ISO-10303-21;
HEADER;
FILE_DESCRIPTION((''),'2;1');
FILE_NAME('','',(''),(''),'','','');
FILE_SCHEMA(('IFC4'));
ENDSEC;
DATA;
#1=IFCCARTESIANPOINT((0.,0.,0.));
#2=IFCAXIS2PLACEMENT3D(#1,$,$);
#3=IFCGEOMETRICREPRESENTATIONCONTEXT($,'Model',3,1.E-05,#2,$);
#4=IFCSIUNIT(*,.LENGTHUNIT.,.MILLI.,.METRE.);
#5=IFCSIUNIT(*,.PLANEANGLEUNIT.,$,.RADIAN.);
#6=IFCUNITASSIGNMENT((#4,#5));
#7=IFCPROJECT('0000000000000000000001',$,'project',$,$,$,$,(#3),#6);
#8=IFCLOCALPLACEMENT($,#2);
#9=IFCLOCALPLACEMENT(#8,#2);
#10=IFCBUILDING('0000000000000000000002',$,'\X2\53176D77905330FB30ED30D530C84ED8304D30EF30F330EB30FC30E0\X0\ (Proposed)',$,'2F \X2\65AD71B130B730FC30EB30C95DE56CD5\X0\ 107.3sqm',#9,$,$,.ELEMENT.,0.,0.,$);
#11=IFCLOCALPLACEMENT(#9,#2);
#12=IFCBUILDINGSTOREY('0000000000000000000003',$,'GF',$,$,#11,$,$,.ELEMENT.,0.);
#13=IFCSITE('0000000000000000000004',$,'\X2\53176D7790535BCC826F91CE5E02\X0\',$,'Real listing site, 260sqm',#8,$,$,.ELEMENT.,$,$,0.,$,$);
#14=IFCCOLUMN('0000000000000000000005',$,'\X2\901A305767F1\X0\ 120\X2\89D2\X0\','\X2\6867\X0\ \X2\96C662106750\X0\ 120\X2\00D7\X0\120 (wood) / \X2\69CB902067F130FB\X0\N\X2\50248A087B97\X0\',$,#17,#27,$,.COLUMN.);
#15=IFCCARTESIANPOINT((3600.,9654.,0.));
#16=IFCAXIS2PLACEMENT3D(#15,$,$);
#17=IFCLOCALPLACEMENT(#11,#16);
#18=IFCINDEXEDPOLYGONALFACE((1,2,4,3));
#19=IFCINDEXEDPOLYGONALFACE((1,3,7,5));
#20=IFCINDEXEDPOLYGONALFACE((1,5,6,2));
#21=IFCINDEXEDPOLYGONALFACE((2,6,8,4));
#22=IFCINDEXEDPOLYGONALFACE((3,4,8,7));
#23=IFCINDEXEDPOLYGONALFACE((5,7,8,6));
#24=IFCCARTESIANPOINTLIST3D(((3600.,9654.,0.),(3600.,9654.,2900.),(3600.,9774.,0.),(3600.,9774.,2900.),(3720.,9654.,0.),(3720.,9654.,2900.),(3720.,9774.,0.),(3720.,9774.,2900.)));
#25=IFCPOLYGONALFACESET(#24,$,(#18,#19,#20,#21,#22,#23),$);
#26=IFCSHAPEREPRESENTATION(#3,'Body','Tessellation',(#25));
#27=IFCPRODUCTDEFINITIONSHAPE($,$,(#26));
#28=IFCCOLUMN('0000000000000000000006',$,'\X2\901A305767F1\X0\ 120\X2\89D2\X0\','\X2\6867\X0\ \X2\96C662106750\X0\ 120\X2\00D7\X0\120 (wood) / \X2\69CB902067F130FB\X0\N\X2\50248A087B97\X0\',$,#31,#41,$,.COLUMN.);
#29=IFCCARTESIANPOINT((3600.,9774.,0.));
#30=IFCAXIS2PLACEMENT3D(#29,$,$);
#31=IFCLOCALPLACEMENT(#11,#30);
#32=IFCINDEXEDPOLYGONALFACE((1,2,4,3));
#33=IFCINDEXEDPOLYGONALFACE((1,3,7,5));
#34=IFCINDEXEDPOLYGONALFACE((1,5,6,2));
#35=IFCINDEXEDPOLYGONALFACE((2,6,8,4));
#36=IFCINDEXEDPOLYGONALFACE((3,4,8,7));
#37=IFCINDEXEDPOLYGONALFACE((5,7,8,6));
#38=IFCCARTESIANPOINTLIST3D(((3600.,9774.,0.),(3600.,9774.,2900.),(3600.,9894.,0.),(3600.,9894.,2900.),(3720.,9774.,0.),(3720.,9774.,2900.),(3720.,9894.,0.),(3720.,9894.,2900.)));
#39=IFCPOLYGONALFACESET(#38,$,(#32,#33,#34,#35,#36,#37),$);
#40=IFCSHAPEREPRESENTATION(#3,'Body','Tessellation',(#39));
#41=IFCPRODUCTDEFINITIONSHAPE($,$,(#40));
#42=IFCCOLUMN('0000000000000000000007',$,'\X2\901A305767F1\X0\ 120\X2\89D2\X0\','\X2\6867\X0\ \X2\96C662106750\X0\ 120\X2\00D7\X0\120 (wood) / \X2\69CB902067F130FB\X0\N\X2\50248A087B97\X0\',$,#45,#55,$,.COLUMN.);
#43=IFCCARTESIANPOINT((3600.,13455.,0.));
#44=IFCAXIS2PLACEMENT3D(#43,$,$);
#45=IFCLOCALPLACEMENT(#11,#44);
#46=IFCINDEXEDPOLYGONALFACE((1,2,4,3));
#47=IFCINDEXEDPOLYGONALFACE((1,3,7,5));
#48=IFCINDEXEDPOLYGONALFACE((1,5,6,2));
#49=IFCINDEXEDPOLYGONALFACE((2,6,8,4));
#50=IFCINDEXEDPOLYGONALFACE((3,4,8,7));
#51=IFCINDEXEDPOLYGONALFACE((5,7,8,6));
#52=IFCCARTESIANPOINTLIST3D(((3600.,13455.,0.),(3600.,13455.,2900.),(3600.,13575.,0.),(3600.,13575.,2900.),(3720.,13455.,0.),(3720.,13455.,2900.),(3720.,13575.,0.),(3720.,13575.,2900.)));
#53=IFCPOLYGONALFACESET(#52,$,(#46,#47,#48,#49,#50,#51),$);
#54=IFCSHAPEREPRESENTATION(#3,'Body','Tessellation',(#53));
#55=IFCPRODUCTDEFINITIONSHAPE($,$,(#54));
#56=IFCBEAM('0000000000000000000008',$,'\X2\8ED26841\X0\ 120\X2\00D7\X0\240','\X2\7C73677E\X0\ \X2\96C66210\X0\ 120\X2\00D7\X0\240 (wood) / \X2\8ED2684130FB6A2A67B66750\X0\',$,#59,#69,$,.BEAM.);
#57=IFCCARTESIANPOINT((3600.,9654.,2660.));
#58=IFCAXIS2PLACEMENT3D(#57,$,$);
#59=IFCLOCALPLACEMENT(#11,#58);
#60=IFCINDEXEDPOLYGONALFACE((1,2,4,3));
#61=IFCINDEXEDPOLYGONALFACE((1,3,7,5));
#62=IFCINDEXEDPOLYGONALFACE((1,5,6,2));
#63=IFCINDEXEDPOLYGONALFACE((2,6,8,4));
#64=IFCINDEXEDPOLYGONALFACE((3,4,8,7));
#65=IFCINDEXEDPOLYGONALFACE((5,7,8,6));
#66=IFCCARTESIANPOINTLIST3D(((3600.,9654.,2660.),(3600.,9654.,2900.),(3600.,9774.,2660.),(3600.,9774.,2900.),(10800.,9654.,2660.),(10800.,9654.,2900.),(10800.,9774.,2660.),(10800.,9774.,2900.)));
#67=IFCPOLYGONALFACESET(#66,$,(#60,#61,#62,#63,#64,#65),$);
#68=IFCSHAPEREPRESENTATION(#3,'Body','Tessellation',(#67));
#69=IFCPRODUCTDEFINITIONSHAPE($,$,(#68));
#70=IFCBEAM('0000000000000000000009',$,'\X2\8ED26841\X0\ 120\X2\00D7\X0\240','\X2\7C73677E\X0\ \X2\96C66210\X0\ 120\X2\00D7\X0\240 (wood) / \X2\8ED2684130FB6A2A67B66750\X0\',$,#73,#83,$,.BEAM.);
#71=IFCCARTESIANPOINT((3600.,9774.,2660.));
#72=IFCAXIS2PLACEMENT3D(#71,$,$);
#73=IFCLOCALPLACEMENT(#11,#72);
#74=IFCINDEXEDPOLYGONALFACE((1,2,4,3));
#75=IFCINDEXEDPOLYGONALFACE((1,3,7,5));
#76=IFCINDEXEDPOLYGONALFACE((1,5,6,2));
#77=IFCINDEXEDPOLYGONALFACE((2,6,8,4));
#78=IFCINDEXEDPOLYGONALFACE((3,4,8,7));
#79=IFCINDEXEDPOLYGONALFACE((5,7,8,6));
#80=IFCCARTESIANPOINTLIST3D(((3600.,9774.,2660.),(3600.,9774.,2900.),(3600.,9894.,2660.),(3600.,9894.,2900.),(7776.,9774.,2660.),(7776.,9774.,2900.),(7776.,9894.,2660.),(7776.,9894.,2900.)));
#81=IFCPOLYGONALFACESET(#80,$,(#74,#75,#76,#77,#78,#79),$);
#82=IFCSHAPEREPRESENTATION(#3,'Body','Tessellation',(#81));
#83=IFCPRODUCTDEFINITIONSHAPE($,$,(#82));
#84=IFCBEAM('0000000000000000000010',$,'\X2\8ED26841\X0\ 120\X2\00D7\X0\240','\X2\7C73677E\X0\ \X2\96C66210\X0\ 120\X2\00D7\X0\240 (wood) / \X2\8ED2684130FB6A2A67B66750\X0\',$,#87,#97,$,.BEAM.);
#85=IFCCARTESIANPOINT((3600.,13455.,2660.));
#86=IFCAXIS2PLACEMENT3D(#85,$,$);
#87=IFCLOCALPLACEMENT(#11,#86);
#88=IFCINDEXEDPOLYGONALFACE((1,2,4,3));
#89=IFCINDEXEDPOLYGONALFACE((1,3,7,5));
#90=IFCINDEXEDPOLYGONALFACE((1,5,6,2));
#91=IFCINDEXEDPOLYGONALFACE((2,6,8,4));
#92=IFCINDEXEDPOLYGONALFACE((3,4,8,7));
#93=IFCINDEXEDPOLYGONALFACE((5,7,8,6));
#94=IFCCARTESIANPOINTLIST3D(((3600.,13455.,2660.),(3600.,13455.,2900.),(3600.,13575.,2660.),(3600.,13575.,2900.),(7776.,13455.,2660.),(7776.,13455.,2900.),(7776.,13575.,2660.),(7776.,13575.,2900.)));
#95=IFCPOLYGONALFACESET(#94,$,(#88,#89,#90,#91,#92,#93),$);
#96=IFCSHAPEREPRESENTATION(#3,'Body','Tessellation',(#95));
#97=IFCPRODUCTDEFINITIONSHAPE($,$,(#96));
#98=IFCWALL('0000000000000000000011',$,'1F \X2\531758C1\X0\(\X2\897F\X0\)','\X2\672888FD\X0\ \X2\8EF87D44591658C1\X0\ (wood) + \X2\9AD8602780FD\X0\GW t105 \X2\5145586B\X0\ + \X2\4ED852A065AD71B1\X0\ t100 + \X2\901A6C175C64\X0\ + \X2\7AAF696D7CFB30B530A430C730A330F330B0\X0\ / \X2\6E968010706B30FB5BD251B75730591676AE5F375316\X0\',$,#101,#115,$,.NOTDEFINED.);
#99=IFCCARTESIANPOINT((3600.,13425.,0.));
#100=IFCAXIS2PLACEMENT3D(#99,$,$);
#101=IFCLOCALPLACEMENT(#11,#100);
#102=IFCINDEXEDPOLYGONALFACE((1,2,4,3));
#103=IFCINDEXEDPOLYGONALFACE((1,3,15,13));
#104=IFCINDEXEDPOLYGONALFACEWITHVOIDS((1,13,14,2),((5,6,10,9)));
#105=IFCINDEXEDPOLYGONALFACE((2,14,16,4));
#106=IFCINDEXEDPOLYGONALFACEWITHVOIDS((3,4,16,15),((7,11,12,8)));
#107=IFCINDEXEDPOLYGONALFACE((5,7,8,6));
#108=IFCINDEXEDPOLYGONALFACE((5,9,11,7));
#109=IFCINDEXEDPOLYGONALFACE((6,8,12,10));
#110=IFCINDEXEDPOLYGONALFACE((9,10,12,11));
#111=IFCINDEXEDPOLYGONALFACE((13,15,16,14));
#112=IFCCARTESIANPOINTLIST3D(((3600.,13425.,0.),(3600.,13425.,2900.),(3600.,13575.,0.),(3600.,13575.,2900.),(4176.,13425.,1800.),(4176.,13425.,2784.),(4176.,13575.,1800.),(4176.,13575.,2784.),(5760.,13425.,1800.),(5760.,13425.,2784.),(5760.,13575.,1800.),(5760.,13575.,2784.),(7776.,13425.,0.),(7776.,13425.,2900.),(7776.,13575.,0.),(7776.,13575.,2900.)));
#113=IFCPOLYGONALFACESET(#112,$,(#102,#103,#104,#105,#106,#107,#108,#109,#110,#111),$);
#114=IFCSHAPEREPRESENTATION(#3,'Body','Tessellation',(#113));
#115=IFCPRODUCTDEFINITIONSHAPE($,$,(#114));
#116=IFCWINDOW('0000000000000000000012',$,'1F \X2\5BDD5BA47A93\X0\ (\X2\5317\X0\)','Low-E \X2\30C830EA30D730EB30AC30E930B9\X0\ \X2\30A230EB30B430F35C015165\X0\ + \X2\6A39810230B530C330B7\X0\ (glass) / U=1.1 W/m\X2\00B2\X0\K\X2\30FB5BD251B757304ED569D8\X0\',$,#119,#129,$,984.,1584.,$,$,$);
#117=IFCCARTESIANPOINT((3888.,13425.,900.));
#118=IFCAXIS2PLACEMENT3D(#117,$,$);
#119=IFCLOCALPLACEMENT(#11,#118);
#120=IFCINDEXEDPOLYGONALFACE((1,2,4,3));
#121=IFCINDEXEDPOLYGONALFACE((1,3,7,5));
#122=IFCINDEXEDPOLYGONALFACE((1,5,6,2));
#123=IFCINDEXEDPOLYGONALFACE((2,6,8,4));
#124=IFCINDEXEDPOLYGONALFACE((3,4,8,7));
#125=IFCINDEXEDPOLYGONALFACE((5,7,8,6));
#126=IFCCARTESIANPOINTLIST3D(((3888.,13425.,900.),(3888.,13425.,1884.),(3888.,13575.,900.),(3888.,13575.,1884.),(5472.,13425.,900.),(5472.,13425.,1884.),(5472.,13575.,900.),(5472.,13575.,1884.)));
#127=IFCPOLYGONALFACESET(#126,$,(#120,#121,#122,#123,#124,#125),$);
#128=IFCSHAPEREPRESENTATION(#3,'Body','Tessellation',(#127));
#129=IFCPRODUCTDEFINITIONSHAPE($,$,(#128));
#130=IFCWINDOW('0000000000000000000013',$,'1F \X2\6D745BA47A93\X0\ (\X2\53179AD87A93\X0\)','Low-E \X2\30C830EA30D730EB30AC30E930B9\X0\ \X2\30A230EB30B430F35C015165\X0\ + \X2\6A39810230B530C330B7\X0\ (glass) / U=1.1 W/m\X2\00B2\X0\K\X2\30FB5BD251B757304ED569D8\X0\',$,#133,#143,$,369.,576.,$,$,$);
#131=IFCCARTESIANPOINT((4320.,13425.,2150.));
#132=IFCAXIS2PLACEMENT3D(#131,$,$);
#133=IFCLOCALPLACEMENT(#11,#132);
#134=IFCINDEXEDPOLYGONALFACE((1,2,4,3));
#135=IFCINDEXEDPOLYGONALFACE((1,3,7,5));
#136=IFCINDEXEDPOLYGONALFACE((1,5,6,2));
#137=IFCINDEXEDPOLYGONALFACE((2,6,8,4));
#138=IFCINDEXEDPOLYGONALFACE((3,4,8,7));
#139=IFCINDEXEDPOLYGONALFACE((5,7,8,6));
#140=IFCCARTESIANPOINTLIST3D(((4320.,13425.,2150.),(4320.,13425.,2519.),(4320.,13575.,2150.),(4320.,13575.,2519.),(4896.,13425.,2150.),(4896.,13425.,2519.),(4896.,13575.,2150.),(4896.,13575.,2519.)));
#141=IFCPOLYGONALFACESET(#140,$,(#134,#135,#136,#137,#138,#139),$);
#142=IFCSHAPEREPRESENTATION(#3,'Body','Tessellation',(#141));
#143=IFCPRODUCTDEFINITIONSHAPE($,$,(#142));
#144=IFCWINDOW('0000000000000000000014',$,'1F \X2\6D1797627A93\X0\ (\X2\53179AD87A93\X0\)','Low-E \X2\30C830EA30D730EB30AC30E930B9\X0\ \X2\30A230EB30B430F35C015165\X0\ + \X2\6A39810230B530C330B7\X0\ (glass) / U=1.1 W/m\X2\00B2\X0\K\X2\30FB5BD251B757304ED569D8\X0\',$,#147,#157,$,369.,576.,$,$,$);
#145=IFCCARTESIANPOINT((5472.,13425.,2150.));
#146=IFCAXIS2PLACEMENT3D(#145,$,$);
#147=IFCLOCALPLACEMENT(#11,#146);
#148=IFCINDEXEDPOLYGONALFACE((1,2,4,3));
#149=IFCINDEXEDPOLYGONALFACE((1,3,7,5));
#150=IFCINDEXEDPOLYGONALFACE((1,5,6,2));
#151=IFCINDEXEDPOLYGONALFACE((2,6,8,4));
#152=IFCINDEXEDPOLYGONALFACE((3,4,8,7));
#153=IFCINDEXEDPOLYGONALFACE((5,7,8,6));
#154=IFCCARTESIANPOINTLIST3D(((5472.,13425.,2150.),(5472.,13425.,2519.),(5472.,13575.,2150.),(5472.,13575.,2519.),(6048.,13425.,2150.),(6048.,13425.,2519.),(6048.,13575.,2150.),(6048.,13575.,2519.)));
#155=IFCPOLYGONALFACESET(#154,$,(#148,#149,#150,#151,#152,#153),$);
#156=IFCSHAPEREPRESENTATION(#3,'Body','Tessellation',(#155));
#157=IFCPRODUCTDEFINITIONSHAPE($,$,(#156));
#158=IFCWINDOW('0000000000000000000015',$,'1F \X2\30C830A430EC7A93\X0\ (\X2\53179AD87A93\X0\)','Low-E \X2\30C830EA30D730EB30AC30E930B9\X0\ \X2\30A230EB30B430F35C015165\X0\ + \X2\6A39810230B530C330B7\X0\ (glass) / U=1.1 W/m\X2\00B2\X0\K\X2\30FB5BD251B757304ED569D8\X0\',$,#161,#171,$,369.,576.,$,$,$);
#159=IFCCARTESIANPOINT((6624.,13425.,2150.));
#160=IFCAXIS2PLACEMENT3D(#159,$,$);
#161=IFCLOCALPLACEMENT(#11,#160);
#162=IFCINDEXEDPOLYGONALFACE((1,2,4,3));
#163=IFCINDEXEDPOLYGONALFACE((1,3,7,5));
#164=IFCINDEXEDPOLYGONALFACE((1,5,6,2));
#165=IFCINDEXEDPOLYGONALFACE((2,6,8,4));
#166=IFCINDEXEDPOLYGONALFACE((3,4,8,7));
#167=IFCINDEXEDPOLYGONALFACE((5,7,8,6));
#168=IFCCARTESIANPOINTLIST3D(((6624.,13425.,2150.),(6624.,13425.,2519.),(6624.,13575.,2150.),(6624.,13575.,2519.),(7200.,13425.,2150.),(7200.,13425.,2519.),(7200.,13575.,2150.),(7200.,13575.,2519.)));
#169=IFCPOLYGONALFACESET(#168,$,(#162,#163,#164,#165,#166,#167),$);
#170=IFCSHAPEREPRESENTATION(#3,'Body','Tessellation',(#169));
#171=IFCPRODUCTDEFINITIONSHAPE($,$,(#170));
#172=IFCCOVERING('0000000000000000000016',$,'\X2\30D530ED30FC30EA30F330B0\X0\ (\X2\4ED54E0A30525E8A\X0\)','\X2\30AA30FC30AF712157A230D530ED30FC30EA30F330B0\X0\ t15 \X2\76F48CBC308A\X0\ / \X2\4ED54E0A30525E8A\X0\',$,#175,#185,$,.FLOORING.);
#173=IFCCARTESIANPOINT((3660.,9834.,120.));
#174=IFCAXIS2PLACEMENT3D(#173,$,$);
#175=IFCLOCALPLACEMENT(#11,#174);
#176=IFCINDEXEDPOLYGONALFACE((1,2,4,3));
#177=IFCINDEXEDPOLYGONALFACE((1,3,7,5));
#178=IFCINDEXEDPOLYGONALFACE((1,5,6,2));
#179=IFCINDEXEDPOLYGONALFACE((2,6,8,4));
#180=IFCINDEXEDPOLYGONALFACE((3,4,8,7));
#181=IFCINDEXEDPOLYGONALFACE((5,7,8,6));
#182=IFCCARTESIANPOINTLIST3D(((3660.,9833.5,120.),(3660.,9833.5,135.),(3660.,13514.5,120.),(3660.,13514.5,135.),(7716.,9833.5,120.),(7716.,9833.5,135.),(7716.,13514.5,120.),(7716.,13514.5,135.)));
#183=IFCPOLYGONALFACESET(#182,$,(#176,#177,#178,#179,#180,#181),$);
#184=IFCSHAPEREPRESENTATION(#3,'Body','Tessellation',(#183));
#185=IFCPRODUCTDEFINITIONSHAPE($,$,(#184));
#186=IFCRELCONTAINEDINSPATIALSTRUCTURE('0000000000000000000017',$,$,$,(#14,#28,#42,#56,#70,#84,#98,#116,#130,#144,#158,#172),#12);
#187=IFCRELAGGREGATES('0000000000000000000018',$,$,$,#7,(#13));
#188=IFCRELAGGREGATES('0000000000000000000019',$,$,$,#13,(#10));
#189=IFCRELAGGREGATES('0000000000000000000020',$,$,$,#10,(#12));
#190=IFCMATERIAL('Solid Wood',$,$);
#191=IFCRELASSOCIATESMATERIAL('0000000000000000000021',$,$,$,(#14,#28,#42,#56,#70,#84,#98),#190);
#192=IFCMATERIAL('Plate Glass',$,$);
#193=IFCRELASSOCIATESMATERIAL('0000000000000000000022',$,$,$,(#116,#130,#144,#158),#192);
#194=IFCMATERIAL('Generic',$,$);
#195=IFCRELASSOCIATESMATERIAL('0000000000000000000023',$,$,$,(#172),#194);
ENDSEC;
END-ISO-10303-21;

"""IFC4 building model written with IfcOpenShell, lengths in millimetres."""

from ifc_helpers import new_model, si_unit, frame, frame_2d, origin, place, context, project, spatial, rectangle, extrude, material, element, fill, save


model = new_model("IFC4")

# Units and contexts
model_context = context("Model", 3, precision=1e-05, world=origin())
ifc_project = project(units=[si_unit("LENGTHUNIT", "METRE", prefix="MILLI"), si_unit("PLANEANGLEUNIT", "RADIAN")], contexts=[model_context])

# Site, building, storey
site_placement = place(None, origin())
site = spatial("IfcSite", under=ifc_project, at=site_placement, Name="北海道富良野市", ObjectType="Real listing site, 260sqm", CompositionType="ELEMENT", RefElevation=0.0)
building_placement = place(site_placement, origin())
building = spatial("IfcBuilding", under=site, at=building_placement, Name="北海道・ロフト付きワンルーム (Proposed)", ObjectType="2F 断熱シールド工法 107.3sqm", CompositionType="ELEMENT", ElevationOfRefHeight=0.0, ElevationOfTerrain=0.0)
storey_placement = place(building_placement, origin())
storey = spatial("IfcBuildingStorey", under=building, at=storey_placement, Name="GF", CompositionType="ELEMENT", Elevation=0.0)

# Columns
ifc_material_1 = material(Name="Solid Wood")
column_1_placement = place(storey_placement, frame((3600.0, 9654.0, 0.0)))
element("IfcColumn", 1, at=column_1_placement, inside=storey, material=ifc_material_1, Name="通し柱 120角", Description="桧 集成材 120×120 (wood) / 構造柱・N値計算", PredefinedType="COLUMN", context=model_context, shape_type="SweptSolid", body=[
    extrude(rectangle(XDim=120.0, YDim=120.0, at=frame_2d((60.0, 60.0))), frame((3600.0, 9654.0, 0.0)), (0.0, 0.0, 1.0), 2900.0),
])
column_2_placement = place(storey_placement, frame((3600.0, 9774.0, 0.0)))
element("IfcColumn", 2, at=column_2_placement, inside=storey, material=ifc_material_1, Name="通し柱 120角", Description="桧 集成材 120×120 (wood) / 構造柱・N値計算", PredefinedType="COLUMN", context=model_context, shape_type="SweptSolid", body=[
    extrude(rectangle(XDim=120.0, YDim=120.0, at=frame_2d((60.0, 60.0))), frame((3600.0, 9774.0, 0.0)), (0.0, 0.0, 1.0), 2900.0),
])
column_3_placement = place(storey_placement, frame((3600.0, 13455.0, 0.0)))
element("IfcColumn", 3, at=column_3_placement, inside=storey, material=ifc_material_1, Name="通し柱 120角", Description="桧 集成材 120×120 (wood) / 構造柱・N値計算", PredefinedType="COLUMN", context=model_context, shape_type="SweptSolid", body=[
    extrude(rectangle(XDim=120.0, YDim=120.0, at=frame_2d((60.0, 60.0))), frame((3600.0, 13455.0, 0.0)), (0.0, 0.0, 1.0), 2900.0),
])

# Beams
beam_1_placement = place(storey_placement, frame((3600.0, 9654.0, 2660.0)))
element("IfcBeam", 4, at=beam_1_placement, inside=storey, material=ifc_material_1, Name="軒桁 120×240", Description="米松 集成 120×240 (wood) / 軒桁・横架材", PredefinedType="BEAM", context=model_context, shape_type="SweptSolid", body=[
    extrude(rectangle(XDim=7200.0, YDim=120.0, at=frame_2d((3600.0, 60.0))), frame((3600.0, 9654.0, 2660.0)), (0.0, 0.0, 1.0), 240.0),
])
beam_2_placement = place(storey_placement, frame((3600.0, 9774.0, 2660.0)))
element("IfcBeam", 5, at=beam_2_placement, inside=storey, material=ifc_material_1, Name="軒桁 120×240", Description="米松 集成 120×240 (wood) / 軒桁・横架材", PredefinedType="BEAM", context=model_context, shape_type="SweptSolid", body=[
    extrude(rectangle(XDim=4176.0, YDim=120.0, at=frame_2d((2088.0, 60.0))), frame((3600.0, 9774.0, 2660.0)), (0.0, 0.0, 1.0), 240.0),
])
beam_3_placement = place(storey_placement, frame((3600.0, 13455.0, 2660.0)))
element("IfcBeam", 6, at=beam_3_placement, inside=storey, material=ifc_material_1, Name="軒桁 120×240", Description="米松 集成 120×240 (wood) / 軒桁・横架材", PredefinedType="BEAM", context=model_context, shape_type="SweptSolid", body=[
    extrude(rectangle(XDim=4176.0, YDim=120.0, at=frame_2d((2088.0, 60.0))), frame((3600.0, 13455.0, 2660.0)), (0.0, 0.0, 1.0), 240.0),
])

# Wall, openings, windows
wall_1_placement = place(storey_placement, frame((3600.0, 13425.0, 0.0)))
wall_1 = element("IfcWall", 7, at=wall_1_placement, inside=storey, material=ifc_material_1, Name="1F 北壁(西)", Description="木製 軸組外壁 (wood) + 高性能GW t105 充填 + 付加断熱 t100 + 通気層 + 窯業系サイディング / 準耐火・寒冷地外皮強化", PredefinedType="NOTDEFINED", context=model_context, shape_type="SweptSolid", body=[
    extrude(rectangle(XDim=4176.0, YDim=150.0, at=frame_2d((2088.0, 75.0))), frame((3600.0, 13425.0, 0.0)), (0.0, 0.0, 1.0), 2900.0),
])
opening_1_placement = place(storey_placement, frame((3888.0, 13425.0, 900.0)))
opening_1 = element("IfcOpeningElement", 8, at=opening_1_placement, cuts=wall_1, PredefinedType="NOTDEFINED", context=model_context, shape_type="SweptSolid", body=[
    extrude(rectangle(XDim=1584.0, YDim=150.0, at=frame_2d((792.0, 75.0))), frame((3888.0, 13425.0, 900.0)), (0.0, 0.0, 1.0), 984.0),
])
opening_2_placement = place(storey_placement, frame((4320.0, 13425.0, 2150.0)))
opening_2 = element("IfcOpeningElement", 9, at=opening_2_placement, cuts=wall_1, PredefinedType="NOTDEFINED", context=model_context, shape_type="SweptSolid", body=[
    extrude(rectangle(XDim=576.0, YDim=150.0, at=frame_2d((288.0, 75.0))), frame((4320.0, 13425.0, 2150.0)), (0.0, 0.0, 1.0), 369.0),
])
opening_3_placement = place(storey_placement, frame((5472.0, 13425.0, 2150.0)))
opening_3 = element("IfcOpeningElement", 10, at=opening_3_placement, cuts=wall_1, PredefinedType="NOTDEFINED", context=model_context, shape_type="SweptSolid", body=[
    extrude(rectangle(XDim=576.0, YDim=150.0, at=frame_2d((288.0, 75.0))), frame((5472.0, 13425.0, 2150.0)), (0.0, 0.0, 1.0), 369.0),
])
opening_4_placement = place(storey_placement, frame((6624.0, 13425.0, 2150.0)))
opening_4 = element("IfcOpeningElement", 11, at=opening_4_placement, cuts=wall_1, PredefinedType="NOTDEFINED", context=model_context, shape_type="SweptSolid", body=[
    extrude(rectangle(XDim=576.0, YDim=150.0, at=frame_2d((288.0, 75.0))), frame((6624.0, 13425.0, 2150.0)), (0.0, 0.0, 1.0), 369.0),
])
ifc_material_2 = material(Name="Plate Glass")
window_1_placement = place(storey_placement, frame((3888.0, 13425.0, 900.0)))
window_1 = element("IfcWindow", 12, at=window_1_placement, inside=storey, material=ifc_material_2, Name="1F 寝室窓 (北)", Description="Low-E トリプルガラス アルゴン封入 + 樹脂サッシ (glass) / U=1.1 W/m²K・寒冷地仕様", OverallHeight=984.0, OverallWidth=1584.0, context=model_context, shape_type="SweptSolid", body=[
    extrude(rectangle(XDim=1584.0, YDim=150.0, at=frame_2d((792.0, 75.0))), frame((3888.0, 13425.0, 900.0)), (0.0, 0.0, 1.0), 984.0),
])
fill(opening_1, window_1)
window_2_placement = place(storey_placement, frame((4320.0, 13425.0, 2150.0)))
window_2 = element("IfcWindow", 13, at=window_2_placement, inside=storey, material=ifc_material_2, Name="1F 浴室窓 (北高窓)", Description="Low-E トリプルガラス アルゴン封入 + 樹脂サッシ (glass) / U=1.1 W/m²K・寒冷地仕様", OverallHeight=369.0, OverallWidth=576.0, context=model_context, shape_type="SweptSolid", body=[
    extrude(rectangle(XDim=576.0, YDim=150.0, at=frame_2d((288.0, 75.0))), frame((4320.0, 13425.0, 2150.0)), (0.0, 0.0, 1.0), 369.0),
])
fill(opening_2, window_2)
window_3_placement = place(storey_placement, frame((5472.0, 13425.0, 2150.0)))
window_3 = element("IfcWindow", 14, at=window_3_placement, inside=storey, material=ifc_material_2, Name="1F 洗面窓 (北高窓)", Description="Low-E トリプルガラス アルゴン封入 + 樹脂サッシ (glass) / U=1.1 W/m²K・寒冷地仕様", OverallHeight=369.0, OverallWidth=576.0, context=model_context, shape_type="SweptSolid", body=[
    extrude(rectangle(XDim=576.0, YDim=150.0, at=frame_2d((288.0, 75.0))), frame((5472.0, 13425.0, 2150.0)), (0.0, 0.0, 1.0), 369.0),
])
fill(opening_3, window_3)
window_4_placement = place(storey_placement, frame((6624.0, 13425.0, 2150.0)))
window_4 = element("IfcWindow", 15, at=window_4_placement, inside=storey, material=ifc_material_2, Name="1F トイレ窓 (北高窓)", Description="Low-E トリプルガラス アルゴン封入 + 樹脂サッシ (glass) / U=1.1 W/m²K・寒冷地仕様", OverallHeight=369.0, OverallWidth=576.0, context=model_context, shape_type="SweptSolid", body=[
    extrude(rectangle(XDim=576.0, YDim=150.0, at=frame_2d((288.0, 75.0))), frame((6624.0, 13425.0, 2150.0)), (0.0, 0.0, 1.0), 369.0),
])
fill(opening_4, window_4)

# Covering
ifc_material_3 = material(Name="Generic")
covering_placement = place(storey_placement, frame((3660.0, 9834.0, 120.0)))
element("IfcCovering", 16, at=covering_placement, inside=storey, material=ifc_material_3, Name="フローリング (仕上げ床)", Description="オーク無垢フローリング t15 直貼り / 仕上げ床", PredefinedType="FLOORING", context=model_context, shape_type="SweptSolid", body=[
    extrude(rectangle(XDim=4056.0, YDim=3681.0, at=frame_2d((2028.0, 1840.0))), frame((3660.0, 9834.0, 120.0)), (0.0, 0.0, 1.0), 15.0),
])

save(model, "model.ifc")
